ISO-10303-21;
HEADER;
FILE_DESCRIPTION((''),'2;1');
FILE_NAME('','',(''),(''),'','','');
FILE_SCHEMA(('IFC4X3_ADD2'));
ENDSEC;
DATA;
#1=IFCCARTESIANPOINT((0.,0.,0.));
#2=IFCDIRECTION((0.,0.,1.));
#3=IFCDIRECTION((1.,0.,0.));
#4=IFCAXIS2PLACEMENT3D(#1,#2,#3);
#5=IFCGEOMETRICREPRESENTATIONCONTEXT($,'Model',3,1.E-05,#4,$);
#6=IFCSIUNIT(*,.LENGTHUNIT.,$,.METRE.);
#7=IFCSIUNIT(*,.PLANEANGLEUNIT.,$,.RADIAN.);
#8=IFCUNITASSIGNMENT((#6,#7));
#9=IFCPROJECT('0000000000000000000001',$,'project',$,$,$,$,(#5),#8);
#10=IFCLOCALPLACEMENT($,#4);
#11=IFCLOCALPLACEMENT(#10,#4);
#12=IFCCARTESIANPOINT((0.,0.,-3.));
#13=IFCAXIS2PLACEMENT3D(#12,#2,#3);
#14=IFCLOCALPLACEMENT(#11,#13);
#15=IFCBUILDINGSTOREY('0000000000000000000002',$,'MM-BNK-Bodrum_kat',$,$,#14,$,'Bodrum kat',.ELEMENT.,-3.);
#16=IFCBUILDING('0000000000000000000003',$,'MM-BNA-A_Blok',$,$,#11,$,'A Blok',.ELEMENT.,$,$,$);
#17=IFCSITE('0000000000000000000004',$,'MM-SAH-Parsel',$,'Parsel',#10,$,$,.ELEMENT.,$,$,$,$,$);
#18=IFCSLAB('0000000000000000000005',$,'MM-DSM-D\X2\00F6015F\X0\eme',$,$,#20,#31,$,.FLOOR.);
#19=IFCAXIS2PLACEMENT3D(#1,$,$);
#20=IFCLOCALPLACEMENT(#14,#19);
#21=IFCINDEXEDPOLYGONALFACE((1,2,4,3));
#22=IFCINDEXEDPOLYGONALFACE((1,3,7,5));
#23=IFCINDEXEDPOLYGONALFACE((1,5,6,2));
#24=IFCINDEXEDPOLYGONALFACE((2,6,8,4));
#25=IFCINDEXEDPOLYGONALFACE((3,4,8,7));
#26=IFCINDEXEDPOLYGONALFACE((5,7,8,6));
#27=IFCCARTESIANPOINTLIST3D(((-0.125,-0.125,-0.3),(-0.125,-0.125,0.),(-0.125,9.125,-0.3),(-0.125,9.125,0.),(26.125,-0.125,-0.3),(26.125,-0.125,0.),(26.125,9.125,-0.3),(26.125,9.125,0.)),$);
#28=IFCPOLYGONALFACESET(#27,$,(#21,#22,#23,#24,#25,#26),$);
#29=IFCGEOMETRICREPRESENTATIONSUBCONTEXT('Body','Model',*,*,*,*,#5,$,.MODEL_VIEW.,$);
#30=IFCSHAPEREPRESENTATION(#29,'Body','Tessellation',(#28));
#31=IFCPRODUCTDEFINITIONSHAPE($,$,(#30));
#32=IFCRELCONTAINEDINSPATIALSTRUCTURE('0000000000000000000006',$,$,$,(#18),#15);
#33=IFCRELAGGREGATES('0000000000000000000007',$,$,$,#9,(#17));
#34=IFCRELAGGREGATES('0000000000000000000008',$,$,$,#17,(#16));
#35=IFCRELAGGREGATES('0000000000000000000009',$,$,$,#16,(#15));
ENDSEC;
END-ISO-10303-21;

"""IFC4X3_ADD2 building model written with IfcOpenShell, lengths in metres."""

from ifc_helpers import new_model, si_unit, frame, origin_with_axes, place, context, subcontext, project, spatial, polyline, outline, extrude, element, save


model = new_model("IFC4X3_ADD2")

# Units and contexts
model_context = context("Model", 3, precision=1e-05, world=origin_with_axes())
body_context = subcontext(model_context, "Body", "Model", "MODEL_VIEW")
ifc_project = project(units=[si_unit("LENGTHUNIT", "METRE"), si_unit("PLANEANGLEUNIT", "RADIAN")], contexts=[model_context])

# Site, building, storey
site_placement = place(None, origin_with_axes())
site = spatial("IfcSite", under=ifc_project, at=site_placement, Name="MM-SAH-Parsel", ObjectType="Parsel", CompositionType="ELEMENT")
building_placement = place(site_placement, origin_with_axes())
building = spatial("IfcBuilding", under=site, at=building_placement, Name="MM-BNA-A_Blok", LongName="A Blok", CompositionType="ELEMENT")
storey_placement = place(building_placement, frame((0.0, 0.0, -3.0), z_axis=(0.0, 0.0, 1.0), x_axis=(1.0, 0.0, 0.0)))
storey = spatial("IfcBuildingStorey", under=building, at=storey_placement, Name="MM-BNK-Bodrum_kat", LongName="Bodrum kat", CompositionType="ELEMENT", Elevation=-3.0)

# Slab
slab_placement = place(storey_placement, origin_with_axes())
element("IfcSlab", 1, at=slab_placement, inside=storey, Name="MM-DSM-Döşeme", PredefinedType="FLOOR", context=body_context, shape_type="SweptSolid", body=[
    extrude(outline(polyline([(-0.125, -0.125), (26.125, -0.125), (26.125, 9.125), (-0.125, 9.125), (-0.125, -0.125)])), frame((0.0, 0.0, -0.3)), (0.0, 0.0, 1.0), 0.3),
])

save(model, "model.ifc")
